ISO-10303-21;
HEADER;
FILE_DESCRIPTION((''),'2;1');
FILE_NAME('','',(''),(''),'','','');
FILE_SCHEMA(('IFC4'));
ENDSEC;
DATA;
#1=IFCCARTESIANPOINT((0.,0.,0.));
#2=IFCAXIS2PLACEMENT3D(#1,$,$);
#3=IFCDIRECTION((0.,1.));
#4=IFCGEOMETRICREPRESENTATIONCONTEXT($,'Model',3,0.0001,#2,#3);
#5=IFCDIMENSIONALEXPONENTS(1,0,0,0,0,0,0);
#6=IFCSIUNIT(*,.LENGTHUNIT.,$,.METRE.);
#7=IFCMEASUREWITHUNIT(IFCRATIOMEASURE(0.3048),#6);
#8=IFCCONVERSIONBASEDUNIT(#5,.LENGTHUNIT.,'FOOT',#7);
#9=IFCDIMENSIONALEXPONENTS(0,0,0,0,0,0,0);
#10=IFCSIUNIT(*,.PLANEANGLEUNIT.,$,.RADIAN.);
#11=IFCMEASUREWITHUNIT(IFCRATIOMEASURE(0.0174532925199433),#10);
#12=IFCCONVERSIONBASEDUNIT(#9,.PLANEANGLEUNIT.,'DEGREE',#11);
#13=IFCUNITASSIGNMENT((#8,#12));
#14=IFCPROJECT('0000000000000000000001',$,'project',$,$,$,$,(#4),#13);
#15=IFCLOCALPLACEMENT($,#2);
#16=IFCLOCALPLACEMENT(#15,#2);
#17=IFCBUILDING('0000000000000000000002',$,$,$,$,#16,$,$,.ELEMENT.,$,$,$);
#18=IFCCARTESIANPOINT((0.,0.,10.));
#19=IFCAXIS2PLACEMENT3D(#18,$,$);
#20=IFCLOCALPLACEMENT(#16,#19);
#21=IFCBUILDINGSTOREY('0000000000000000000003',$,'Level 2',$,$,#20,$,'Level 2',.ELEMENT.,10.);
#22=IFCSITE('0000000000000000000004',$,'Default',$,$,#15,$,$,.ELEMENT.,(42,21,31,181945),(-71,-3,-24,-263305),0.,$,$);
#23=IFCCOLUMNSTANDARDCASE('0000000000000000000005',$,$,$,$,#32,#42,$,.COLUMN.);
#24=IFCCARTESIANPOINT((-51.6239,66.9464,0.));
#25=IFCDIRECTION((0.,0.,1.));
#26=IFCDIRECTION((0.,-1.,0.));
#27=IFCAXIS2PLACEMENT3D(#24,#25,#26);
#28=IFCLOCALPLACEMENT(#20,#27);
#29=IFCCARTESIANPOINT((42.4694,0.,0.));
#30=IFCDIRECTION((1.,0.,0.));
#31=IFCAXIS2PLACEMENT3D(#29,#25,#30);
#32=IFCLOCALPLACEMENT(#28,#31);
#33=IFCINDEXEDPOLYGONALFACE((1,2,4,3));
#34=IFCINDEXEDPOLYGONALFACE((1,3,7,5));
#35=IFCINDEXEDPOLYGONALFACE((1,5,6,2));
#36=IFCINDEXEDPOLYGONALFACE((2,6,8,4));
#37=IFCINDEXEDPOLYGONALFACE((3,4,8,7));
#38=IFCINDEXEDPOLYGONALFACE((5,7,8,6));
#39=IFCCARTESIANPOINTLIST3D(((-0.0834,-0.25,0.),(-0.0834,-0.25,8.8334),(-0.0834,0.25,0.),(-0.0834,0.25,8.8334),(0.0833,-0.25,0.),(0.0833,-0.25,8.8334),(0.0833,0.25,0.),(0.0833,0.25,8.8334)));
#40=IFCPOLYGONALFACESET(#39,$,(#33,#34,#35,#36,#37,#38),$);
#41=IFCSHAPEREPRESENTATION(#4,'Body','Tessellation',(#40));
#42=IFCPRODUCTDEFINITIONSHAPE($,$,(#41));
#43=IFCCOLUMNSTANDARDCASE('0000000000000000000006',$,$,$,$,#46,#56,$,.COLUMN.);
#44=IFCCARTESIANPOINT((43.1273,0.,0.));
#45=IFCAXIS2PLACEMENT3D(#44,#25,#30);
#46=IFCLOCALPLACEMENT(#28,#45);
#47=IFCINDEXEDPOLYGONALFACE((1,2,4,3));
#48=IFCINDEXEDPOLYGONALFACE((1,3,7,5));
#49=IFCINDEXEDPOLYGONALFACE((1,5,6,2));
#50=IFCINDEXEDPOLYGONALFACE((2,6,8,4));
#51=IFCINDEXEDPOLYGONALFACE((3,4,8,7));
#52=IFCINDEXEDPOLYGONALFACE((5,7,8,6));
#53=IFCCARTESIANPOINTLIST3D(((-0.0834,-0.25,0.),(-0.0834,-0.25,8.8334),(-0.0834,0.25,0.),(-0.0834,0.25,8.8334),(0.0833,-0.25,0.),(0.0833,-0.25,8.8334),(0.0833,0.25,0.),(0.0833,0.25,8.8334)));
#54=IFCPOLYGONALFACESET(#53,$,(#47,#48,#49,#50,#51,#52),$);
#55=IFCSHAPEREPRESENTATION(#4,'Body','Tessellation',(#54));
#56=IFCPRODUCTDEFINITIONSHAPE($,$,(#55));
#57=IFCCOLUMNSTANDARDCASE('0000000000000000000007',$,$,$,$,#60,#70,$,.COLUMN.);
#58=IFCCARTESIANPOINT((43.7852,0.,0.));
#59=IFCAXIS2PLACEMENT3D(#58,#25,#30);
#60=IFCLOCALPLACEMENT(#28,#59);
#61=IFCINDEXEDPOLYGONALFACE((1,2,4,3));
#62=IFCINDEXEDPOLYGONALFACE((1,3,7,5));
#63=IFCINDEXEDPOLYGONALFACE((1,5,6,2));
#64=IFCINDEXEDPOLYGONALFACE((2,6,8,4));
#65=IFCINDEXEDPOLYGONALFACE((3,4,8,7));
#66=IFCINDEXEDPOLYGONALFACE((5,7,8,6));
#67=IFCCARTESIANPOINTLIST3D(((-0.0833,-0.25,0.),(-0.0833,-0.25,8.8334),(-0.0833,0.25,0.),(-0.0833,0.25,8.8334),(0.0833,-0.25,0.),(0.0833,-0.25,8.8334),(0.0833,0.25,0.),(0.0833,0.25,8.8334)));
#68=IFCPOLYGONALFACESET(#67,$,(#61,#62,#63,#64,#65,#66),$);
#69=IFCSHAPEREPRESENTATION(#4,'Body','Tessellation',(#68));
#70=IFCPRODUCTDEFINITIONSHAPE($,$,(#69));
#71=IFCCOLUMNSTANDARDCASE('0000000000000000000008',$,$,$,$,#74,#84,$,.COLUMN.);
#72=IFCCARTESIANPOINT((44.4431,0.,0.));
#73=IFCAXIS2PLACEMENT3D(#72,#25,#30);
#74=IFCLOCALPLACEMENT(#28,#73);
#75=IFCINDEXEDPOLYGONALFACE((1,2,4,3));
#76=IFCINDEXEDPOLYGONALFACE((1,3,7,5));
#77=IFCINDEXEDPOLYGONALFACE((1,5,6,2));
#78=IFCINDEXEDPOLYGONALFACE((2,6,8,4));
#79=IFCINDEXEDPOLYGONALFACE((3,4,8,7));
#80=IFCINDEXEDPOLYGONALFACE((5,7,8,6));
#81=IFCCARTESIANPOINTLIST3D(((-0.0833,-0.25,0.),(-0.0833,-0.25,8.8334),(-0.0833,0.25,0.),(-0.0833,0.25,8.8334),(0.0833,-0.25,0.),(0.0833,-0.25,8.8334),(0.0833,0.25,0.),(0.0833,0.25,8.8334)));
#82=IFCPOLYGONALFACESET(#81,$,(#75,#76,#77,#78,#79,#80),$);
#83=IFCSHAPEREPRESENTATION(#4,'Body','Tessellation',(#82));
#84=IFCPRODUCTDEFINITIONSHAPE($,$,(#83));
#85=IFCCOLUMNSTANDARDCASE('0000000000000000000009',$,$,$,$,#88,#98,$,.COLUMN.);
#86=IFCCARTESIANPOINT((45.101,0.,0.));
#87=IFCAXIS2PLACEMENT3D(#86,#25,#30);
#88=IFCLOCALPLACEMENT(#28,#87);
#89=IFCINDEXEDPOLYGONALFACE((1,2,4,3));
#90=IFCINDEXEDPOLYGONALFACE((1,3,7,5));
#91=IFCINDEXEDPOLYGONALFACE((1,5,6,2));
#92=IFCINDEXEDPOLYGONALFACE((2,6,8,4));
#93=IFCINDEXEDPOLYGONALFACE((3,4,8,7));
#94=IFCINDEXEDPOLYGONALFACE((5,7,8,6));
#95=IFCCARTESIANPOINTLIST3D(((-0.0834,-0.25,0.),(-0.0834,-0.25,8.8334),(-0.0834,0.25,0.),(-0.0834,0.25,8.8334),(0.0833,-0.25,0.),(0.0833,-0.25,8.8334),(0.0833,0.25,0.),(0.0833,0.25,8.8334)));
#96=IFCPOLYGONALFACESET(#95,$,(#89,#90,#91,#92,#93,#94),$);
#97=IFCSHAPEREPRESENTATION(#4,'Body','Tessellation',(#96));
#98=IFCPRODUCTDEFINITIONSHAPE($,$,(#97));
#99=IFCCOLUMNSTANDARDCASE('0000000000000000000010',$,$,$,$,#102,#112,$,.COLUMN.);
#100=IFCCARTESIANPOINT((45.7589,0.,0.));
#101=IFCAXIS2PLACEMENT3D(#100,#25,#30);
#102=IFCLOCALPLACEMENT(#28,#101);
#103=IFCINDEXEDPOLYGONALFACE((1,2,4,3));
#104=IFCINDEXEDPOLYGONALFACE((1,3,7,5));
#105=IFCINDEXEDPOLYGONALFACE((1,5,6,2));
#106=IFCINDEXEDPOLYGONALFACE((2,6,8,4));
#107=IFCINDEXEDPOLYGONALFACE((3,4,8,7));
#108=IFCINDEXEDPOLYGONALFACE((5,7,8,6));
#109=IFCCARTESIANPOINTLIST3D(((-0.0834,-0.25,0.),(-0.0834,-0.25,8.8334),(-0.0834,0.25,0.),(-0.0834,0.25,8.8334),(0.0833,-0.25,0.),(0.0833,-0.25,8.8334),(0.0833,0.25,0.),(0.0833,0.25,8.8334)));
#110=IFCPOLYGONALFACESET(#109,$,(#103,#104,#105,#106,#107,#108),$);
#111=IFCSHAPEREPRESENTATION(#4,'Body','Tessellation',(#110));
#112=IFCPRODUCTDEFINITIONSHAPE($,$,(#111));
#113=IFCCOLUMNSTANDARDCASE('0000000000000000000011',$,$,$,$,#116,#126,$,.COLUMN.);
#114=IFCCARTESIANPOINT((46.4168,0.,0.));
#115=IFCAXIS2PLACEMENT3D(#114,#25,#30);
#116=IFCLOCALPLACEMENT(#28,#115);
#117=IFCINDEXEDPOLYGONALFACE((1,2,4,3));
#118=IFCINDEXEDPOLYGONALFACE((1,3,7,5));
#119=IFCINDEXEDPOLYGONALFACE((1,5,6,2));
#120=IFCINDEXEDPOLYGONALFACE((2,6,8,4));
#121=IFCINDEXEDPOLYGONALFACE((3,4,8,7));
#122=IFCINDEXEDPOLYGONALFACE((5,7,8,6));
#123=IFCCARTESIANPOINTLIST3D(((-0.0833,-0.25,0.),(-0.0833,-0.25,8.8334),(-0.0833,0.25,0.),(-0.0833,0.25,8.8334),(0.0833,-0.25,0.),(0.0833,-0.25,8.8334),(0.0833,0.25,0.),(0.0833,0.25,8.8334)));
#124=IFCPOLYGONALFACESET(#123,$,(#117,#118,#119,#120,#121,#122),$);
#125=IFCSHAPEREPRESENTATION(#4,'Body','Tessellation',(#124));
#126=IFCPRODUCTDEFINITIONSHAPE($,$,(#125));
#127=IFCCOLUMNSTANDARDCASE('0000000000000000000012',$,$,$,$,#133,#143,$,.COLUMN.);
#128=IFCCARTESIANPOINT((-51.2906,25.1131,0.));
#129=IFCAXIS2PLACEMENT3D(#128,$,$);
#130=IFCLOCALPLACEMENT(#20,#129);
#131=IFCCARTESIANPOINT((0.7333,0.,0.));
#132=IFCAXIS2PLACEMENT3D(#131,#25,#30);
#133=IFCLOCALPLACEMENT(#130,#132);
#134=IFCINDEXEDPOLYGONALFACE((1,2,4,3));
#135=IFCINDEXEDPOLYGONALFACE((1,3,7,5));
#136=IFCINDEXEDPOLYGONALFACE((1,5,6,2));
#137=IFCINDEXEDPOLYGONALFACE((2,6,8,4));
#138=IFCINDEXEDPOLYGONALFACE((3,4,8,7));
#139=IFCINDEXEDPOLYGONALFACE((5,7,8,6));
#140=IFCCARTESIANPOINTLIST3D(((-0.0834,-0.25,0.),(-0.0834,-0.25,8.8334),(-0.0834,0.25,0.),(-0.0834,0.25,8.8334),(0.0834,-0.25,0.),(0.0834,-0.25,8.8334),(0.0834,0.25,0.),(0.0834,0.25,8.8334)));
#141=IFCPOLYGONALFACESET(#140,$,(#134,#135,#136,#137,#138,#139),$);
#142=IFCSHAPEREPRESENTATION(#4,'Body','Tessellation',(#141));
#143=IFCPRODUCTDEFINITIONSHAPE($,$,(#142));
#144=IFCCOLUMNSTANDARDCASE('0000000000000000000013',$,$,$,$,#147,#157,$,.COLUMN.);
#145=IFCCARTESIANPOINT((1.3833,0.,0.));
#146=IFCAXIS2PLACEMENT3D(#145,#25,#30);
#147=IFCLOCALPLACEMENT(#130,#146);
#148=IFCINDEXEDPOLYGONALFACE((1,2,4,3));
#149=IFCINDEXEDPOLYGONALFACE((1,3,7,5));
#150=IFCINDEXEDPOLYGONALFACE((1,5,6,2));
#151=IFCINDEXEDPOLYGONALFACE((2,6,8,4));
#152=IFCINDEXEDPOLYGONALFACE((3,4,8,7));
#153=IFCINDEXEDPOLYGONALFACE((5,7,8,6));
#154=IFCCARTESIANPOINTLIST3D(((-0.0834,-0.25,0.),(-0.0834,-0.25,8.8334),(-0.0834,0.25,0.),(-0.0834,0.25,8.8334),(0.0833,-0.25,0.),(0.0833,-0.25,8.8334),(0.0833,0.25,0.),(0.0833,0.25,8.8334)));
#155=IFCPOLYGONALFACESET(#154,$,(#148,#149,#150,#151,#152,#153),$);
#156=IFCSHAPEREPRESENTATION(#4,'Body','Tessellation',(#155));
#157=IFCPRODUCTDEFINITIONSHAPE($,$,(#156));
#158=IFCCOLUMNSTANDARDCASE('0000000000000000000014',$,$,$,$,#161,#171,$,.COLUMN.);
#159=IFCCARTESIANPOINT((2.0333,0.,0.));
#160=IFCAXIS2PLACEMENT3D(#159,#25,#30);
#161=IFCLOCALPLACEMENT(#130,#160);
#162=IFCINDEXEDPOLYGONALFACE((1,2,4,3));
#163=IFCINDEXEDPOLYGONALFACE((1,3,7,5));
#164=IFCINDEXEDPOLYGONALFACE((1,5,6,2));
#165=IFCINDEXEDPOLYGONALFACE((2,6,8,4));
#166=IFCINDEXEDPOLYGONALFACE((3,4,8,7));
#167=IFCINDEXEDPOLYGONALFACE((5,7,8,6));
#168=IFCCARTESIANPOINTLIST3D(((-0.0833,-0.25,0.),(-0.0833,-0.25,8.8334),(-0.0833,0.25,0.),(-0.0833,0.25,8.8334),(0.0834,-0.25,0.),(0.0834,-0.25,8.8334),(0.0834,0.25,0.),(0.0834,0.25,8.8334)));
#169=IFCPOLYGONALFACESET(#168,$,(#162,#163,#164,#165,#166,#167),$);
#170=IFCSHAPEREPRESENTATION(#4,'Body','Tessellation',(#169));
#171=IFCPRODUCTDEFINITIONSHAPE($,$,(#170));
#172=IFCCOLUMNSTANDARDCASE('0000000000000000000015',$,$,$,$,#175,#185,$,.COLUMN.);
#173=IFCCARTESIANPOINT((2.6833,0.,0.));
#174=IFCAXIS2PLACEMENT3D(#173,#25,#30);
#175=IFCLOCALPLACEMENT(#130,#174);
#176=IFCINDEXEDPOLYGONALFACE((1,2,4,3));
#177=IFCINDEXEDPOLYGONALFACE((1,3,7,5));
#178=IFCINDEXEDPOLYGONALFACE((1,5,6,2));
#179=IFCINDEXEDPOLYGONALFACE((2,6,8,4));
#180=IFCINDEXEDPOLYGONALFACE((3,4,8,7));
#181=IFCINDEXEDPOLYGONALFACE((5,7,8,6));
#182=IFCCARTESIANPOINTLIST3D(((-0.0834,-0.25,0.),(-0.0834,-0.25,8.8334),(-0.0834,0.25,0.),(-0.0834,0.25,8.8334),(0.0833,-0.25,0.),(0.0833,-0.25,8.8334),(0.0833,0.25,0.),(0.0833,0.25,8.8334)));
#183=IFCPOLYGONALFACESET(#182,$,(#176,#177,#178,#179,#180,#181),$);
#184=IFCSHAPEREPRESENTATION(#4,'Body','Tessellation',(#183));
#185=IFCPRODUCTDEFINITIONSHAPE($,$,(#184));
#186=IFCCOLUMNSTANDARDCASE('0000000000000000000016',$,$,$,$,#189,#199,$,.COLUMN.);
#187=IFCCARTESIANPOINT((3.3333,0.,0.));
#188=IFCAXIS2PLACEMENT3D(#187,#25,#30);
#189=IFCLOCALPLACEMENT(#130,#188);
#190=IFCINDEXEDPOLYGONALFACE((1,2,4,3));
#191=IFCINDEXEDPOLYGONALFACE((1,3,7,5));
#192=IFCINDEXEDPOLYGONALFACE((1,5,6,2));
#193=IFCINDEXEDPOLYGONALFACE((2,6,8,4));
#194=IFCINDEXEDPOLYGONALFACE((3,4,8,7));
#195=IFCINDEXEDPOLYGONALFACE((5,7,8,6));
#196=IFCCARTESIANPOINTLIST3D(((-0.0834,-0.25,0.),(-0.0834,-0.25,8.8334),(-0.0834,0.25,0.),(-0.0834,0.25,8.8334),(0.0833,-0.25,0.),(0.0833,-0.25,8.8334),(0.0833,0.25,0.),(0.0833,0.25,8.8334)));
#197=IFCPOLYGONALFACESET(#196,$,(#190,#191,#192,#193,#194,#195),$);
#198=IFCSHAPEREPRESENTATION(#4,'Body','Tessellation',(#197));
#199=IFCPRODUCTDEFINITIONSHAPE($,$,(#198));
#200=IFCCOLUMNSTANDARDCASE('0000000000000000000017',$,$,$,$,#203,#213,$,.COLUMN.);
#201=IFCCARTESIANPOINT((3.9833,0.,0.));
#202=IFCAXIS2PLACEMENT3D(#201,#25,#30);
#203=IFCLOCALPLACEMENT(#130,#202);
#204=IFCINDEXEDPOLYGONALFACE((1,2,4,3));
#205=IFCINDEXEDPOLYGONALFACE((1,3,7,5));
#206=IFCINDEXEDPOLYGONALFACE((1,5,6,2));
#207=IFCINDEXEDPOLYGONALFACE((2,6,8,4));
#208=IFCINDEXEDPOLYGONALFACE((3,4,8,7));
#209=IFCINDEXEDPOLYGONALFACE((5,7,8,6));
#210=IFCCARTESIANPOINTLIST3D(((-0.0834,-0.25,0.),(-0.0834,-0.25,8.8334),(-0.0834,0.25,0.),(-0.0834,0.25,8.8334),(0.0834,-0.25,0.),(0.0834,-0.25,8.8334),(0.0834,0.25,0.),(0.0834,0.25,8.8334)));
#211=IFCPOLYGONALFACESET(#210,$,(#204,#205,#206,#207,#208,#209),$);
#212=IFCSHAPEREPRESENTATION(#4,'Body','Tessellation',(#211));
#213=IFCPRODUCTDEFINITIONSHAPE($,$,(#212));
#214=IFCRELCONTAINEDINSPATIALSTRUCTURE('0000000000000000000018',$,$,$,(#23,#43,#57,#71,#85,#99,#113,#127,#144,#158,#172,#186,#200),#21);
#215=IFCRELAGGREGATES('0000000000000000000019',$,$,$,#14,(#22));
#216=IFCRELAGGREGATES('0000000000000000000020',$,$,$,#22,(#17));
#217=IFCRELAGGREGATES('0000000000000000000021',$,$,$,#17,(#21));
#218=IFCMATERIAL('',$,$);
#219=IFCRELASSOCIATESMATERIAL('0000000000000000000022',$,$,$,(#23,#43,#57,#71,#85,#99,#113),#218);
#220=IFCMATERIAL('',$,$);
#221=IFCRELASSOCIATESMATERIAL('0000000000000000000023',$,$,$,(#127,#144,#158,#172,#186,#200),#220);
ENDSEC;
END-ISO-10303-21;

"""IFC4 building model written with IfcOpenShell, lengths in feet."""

from ifc_helpers import new_model, entity, si_unit, converted_unit, direction, frame, origin, place, context, project, spatial, rectangle, extrude, material, element, save


model = new_model("IFC4")

# Units and contexts
model_context = context("Model", 3, precision=0.0001, world=origin(), true_north=direction((0.0, 1.0)))
ifc_project = project(units=[converted_unit("LENGTHUNIT", "FOOT", entity("IfcRatioMeasure", 0.3048), si_unit("LENGTHUNIT", "METRE"), dimensions=[1, 0, 0, 0, 0, 0, 0]), converted_unit("PLANEANGLEUNIT", "DEGREE", entity("IfcRatioMeasure", 0.0174532925199433), si_unit("PLANEANGLEUNIT", "RADIAN"), dimensions=[0, 0, 0, 0, 0, 0, 0])], contexts=[model_context])

# Site, building, storey
site_placement = place(None, origin())
site = spatial("IfcSite", under=ifc_project, at=site_placement, Name="Default", CompositionType="ELEMENT", RefLatitude=(42, 21, 31, 181945), RefLongitude=(-71, -3, -24, -263305), RefElevation=0.0)
building_placement = place(site_placement, origin())
building = spatial("IfcBuilding", under=site, at=building_placement, CompositionType="ELEMENT")
storey_placement = place(building_placement, frame((0.0, 0.0, 10.0)))
storey = spatial("IfcBuildingStorey", under=building, at=storey_placement, Name="Level 2", LongName="Level 2", CompositionType="ELEMENT", Elevation=10.0)

# Columns
ifc_material_1 = material(Name="")
placement_1 = place(storey_placement, frame((-51.6239, 66.9464, 0.0), z_axis=(0.0, 0.0, 1.0), x_axis=(0.0, -1.0, 0.0)))
for number, where, z_axis, x_axis in (
    (1, (42.4694, 0.0, 0.0), (0.0, 0.0, 1.0), (1.0, 0.0, 0.0)),
    (2, (43.1273, 0.0, 0.0), (0.0, 0.0, 1.0), (1.0, 0.0, 0.0)),
    (3, (43.7852, 0.0, 0.0), (0.0, 0.0, 1.0), (1.0, 0.0, 0.0)),
    (4, (44.4431, 0.0, 0.0), (0.0, 0.0, 1.0), (1.0, 0.0, 0.0)),
    (5, (45.101, 0.0, 0.0), (0.0, 0.0, 1.0), (1.0, 0.0, 0.0)),
    (6, (45.7589, 0.0, 0.0), (0.0, 0.0, 1.0), (1.0, 0.0, 0.0)),
    (7, (46.4168, 0.0, 0.0), (0.0, 0.0, 1.0), (1.0, 0.0, 0.0)),
):
    element("IfcColumnStandardCase", number, at=place(placement_1, frame(where, z_axis=z_axis, x_axis=x_axis)), inside=storey, material=ifc_material_1, PredefinedType="COLUMN", context=model_context, shape_type="SweptSolid", body=[
        extrude(rectangle(XDim=0.1667, YDim=0.5), origin(), (0.0, 0.0, 1.0), 8.8334),
    ])
ifc_material_2 = material(Name="")
placement_2 = place(storey_placement, frame((-51.2906, 25.1131, 0.0)))
for number, where, z_axis, x_axis in (
    (8, (0.7333, 0.0, 0.0), (0.0, 0.0, 1.0), (1.0, 0.0, 0.0)),
    (9, (1.3833, 0.0, 0.0), (0.0, 0.0, 1.0), (1.0, 0.0, 0.0)),
    (10, (2.0333, 0.0, 0.0), (0.0, 0.0, 1.0), (1.0, 0.0, 0.0)),
    (11, (2.6833, 0.0, 0.0), (0.0, 0.0, 1.0), (1.0, 0.0, 0.0)),
    (12, (3.3333, 0.0, 0.0), (0.0, 0.0, 1.0), (1.0, 0.0, 0.0)),
    (13, (3.9833, 0.0, 0.0), (0.0, 0.0, 1.0), (1.0, 0.0, 0.0)),
):
    element("IfcColumnStandardCase", number, at=place(placement_2, frame(where, z_axis=z_axis, x_axis=x_axis)), inside=storey, material=ifc_material_2, PredefinedType="COLUMN", context=model_context, shape_type="SweptSolid", body=[
        extrude(rectangle(XDim=0.1667, YDim=0.5), origin(), (0.0, 0.0, 1.0), 8.8334),
    ])

save(model, "model.ifc")
